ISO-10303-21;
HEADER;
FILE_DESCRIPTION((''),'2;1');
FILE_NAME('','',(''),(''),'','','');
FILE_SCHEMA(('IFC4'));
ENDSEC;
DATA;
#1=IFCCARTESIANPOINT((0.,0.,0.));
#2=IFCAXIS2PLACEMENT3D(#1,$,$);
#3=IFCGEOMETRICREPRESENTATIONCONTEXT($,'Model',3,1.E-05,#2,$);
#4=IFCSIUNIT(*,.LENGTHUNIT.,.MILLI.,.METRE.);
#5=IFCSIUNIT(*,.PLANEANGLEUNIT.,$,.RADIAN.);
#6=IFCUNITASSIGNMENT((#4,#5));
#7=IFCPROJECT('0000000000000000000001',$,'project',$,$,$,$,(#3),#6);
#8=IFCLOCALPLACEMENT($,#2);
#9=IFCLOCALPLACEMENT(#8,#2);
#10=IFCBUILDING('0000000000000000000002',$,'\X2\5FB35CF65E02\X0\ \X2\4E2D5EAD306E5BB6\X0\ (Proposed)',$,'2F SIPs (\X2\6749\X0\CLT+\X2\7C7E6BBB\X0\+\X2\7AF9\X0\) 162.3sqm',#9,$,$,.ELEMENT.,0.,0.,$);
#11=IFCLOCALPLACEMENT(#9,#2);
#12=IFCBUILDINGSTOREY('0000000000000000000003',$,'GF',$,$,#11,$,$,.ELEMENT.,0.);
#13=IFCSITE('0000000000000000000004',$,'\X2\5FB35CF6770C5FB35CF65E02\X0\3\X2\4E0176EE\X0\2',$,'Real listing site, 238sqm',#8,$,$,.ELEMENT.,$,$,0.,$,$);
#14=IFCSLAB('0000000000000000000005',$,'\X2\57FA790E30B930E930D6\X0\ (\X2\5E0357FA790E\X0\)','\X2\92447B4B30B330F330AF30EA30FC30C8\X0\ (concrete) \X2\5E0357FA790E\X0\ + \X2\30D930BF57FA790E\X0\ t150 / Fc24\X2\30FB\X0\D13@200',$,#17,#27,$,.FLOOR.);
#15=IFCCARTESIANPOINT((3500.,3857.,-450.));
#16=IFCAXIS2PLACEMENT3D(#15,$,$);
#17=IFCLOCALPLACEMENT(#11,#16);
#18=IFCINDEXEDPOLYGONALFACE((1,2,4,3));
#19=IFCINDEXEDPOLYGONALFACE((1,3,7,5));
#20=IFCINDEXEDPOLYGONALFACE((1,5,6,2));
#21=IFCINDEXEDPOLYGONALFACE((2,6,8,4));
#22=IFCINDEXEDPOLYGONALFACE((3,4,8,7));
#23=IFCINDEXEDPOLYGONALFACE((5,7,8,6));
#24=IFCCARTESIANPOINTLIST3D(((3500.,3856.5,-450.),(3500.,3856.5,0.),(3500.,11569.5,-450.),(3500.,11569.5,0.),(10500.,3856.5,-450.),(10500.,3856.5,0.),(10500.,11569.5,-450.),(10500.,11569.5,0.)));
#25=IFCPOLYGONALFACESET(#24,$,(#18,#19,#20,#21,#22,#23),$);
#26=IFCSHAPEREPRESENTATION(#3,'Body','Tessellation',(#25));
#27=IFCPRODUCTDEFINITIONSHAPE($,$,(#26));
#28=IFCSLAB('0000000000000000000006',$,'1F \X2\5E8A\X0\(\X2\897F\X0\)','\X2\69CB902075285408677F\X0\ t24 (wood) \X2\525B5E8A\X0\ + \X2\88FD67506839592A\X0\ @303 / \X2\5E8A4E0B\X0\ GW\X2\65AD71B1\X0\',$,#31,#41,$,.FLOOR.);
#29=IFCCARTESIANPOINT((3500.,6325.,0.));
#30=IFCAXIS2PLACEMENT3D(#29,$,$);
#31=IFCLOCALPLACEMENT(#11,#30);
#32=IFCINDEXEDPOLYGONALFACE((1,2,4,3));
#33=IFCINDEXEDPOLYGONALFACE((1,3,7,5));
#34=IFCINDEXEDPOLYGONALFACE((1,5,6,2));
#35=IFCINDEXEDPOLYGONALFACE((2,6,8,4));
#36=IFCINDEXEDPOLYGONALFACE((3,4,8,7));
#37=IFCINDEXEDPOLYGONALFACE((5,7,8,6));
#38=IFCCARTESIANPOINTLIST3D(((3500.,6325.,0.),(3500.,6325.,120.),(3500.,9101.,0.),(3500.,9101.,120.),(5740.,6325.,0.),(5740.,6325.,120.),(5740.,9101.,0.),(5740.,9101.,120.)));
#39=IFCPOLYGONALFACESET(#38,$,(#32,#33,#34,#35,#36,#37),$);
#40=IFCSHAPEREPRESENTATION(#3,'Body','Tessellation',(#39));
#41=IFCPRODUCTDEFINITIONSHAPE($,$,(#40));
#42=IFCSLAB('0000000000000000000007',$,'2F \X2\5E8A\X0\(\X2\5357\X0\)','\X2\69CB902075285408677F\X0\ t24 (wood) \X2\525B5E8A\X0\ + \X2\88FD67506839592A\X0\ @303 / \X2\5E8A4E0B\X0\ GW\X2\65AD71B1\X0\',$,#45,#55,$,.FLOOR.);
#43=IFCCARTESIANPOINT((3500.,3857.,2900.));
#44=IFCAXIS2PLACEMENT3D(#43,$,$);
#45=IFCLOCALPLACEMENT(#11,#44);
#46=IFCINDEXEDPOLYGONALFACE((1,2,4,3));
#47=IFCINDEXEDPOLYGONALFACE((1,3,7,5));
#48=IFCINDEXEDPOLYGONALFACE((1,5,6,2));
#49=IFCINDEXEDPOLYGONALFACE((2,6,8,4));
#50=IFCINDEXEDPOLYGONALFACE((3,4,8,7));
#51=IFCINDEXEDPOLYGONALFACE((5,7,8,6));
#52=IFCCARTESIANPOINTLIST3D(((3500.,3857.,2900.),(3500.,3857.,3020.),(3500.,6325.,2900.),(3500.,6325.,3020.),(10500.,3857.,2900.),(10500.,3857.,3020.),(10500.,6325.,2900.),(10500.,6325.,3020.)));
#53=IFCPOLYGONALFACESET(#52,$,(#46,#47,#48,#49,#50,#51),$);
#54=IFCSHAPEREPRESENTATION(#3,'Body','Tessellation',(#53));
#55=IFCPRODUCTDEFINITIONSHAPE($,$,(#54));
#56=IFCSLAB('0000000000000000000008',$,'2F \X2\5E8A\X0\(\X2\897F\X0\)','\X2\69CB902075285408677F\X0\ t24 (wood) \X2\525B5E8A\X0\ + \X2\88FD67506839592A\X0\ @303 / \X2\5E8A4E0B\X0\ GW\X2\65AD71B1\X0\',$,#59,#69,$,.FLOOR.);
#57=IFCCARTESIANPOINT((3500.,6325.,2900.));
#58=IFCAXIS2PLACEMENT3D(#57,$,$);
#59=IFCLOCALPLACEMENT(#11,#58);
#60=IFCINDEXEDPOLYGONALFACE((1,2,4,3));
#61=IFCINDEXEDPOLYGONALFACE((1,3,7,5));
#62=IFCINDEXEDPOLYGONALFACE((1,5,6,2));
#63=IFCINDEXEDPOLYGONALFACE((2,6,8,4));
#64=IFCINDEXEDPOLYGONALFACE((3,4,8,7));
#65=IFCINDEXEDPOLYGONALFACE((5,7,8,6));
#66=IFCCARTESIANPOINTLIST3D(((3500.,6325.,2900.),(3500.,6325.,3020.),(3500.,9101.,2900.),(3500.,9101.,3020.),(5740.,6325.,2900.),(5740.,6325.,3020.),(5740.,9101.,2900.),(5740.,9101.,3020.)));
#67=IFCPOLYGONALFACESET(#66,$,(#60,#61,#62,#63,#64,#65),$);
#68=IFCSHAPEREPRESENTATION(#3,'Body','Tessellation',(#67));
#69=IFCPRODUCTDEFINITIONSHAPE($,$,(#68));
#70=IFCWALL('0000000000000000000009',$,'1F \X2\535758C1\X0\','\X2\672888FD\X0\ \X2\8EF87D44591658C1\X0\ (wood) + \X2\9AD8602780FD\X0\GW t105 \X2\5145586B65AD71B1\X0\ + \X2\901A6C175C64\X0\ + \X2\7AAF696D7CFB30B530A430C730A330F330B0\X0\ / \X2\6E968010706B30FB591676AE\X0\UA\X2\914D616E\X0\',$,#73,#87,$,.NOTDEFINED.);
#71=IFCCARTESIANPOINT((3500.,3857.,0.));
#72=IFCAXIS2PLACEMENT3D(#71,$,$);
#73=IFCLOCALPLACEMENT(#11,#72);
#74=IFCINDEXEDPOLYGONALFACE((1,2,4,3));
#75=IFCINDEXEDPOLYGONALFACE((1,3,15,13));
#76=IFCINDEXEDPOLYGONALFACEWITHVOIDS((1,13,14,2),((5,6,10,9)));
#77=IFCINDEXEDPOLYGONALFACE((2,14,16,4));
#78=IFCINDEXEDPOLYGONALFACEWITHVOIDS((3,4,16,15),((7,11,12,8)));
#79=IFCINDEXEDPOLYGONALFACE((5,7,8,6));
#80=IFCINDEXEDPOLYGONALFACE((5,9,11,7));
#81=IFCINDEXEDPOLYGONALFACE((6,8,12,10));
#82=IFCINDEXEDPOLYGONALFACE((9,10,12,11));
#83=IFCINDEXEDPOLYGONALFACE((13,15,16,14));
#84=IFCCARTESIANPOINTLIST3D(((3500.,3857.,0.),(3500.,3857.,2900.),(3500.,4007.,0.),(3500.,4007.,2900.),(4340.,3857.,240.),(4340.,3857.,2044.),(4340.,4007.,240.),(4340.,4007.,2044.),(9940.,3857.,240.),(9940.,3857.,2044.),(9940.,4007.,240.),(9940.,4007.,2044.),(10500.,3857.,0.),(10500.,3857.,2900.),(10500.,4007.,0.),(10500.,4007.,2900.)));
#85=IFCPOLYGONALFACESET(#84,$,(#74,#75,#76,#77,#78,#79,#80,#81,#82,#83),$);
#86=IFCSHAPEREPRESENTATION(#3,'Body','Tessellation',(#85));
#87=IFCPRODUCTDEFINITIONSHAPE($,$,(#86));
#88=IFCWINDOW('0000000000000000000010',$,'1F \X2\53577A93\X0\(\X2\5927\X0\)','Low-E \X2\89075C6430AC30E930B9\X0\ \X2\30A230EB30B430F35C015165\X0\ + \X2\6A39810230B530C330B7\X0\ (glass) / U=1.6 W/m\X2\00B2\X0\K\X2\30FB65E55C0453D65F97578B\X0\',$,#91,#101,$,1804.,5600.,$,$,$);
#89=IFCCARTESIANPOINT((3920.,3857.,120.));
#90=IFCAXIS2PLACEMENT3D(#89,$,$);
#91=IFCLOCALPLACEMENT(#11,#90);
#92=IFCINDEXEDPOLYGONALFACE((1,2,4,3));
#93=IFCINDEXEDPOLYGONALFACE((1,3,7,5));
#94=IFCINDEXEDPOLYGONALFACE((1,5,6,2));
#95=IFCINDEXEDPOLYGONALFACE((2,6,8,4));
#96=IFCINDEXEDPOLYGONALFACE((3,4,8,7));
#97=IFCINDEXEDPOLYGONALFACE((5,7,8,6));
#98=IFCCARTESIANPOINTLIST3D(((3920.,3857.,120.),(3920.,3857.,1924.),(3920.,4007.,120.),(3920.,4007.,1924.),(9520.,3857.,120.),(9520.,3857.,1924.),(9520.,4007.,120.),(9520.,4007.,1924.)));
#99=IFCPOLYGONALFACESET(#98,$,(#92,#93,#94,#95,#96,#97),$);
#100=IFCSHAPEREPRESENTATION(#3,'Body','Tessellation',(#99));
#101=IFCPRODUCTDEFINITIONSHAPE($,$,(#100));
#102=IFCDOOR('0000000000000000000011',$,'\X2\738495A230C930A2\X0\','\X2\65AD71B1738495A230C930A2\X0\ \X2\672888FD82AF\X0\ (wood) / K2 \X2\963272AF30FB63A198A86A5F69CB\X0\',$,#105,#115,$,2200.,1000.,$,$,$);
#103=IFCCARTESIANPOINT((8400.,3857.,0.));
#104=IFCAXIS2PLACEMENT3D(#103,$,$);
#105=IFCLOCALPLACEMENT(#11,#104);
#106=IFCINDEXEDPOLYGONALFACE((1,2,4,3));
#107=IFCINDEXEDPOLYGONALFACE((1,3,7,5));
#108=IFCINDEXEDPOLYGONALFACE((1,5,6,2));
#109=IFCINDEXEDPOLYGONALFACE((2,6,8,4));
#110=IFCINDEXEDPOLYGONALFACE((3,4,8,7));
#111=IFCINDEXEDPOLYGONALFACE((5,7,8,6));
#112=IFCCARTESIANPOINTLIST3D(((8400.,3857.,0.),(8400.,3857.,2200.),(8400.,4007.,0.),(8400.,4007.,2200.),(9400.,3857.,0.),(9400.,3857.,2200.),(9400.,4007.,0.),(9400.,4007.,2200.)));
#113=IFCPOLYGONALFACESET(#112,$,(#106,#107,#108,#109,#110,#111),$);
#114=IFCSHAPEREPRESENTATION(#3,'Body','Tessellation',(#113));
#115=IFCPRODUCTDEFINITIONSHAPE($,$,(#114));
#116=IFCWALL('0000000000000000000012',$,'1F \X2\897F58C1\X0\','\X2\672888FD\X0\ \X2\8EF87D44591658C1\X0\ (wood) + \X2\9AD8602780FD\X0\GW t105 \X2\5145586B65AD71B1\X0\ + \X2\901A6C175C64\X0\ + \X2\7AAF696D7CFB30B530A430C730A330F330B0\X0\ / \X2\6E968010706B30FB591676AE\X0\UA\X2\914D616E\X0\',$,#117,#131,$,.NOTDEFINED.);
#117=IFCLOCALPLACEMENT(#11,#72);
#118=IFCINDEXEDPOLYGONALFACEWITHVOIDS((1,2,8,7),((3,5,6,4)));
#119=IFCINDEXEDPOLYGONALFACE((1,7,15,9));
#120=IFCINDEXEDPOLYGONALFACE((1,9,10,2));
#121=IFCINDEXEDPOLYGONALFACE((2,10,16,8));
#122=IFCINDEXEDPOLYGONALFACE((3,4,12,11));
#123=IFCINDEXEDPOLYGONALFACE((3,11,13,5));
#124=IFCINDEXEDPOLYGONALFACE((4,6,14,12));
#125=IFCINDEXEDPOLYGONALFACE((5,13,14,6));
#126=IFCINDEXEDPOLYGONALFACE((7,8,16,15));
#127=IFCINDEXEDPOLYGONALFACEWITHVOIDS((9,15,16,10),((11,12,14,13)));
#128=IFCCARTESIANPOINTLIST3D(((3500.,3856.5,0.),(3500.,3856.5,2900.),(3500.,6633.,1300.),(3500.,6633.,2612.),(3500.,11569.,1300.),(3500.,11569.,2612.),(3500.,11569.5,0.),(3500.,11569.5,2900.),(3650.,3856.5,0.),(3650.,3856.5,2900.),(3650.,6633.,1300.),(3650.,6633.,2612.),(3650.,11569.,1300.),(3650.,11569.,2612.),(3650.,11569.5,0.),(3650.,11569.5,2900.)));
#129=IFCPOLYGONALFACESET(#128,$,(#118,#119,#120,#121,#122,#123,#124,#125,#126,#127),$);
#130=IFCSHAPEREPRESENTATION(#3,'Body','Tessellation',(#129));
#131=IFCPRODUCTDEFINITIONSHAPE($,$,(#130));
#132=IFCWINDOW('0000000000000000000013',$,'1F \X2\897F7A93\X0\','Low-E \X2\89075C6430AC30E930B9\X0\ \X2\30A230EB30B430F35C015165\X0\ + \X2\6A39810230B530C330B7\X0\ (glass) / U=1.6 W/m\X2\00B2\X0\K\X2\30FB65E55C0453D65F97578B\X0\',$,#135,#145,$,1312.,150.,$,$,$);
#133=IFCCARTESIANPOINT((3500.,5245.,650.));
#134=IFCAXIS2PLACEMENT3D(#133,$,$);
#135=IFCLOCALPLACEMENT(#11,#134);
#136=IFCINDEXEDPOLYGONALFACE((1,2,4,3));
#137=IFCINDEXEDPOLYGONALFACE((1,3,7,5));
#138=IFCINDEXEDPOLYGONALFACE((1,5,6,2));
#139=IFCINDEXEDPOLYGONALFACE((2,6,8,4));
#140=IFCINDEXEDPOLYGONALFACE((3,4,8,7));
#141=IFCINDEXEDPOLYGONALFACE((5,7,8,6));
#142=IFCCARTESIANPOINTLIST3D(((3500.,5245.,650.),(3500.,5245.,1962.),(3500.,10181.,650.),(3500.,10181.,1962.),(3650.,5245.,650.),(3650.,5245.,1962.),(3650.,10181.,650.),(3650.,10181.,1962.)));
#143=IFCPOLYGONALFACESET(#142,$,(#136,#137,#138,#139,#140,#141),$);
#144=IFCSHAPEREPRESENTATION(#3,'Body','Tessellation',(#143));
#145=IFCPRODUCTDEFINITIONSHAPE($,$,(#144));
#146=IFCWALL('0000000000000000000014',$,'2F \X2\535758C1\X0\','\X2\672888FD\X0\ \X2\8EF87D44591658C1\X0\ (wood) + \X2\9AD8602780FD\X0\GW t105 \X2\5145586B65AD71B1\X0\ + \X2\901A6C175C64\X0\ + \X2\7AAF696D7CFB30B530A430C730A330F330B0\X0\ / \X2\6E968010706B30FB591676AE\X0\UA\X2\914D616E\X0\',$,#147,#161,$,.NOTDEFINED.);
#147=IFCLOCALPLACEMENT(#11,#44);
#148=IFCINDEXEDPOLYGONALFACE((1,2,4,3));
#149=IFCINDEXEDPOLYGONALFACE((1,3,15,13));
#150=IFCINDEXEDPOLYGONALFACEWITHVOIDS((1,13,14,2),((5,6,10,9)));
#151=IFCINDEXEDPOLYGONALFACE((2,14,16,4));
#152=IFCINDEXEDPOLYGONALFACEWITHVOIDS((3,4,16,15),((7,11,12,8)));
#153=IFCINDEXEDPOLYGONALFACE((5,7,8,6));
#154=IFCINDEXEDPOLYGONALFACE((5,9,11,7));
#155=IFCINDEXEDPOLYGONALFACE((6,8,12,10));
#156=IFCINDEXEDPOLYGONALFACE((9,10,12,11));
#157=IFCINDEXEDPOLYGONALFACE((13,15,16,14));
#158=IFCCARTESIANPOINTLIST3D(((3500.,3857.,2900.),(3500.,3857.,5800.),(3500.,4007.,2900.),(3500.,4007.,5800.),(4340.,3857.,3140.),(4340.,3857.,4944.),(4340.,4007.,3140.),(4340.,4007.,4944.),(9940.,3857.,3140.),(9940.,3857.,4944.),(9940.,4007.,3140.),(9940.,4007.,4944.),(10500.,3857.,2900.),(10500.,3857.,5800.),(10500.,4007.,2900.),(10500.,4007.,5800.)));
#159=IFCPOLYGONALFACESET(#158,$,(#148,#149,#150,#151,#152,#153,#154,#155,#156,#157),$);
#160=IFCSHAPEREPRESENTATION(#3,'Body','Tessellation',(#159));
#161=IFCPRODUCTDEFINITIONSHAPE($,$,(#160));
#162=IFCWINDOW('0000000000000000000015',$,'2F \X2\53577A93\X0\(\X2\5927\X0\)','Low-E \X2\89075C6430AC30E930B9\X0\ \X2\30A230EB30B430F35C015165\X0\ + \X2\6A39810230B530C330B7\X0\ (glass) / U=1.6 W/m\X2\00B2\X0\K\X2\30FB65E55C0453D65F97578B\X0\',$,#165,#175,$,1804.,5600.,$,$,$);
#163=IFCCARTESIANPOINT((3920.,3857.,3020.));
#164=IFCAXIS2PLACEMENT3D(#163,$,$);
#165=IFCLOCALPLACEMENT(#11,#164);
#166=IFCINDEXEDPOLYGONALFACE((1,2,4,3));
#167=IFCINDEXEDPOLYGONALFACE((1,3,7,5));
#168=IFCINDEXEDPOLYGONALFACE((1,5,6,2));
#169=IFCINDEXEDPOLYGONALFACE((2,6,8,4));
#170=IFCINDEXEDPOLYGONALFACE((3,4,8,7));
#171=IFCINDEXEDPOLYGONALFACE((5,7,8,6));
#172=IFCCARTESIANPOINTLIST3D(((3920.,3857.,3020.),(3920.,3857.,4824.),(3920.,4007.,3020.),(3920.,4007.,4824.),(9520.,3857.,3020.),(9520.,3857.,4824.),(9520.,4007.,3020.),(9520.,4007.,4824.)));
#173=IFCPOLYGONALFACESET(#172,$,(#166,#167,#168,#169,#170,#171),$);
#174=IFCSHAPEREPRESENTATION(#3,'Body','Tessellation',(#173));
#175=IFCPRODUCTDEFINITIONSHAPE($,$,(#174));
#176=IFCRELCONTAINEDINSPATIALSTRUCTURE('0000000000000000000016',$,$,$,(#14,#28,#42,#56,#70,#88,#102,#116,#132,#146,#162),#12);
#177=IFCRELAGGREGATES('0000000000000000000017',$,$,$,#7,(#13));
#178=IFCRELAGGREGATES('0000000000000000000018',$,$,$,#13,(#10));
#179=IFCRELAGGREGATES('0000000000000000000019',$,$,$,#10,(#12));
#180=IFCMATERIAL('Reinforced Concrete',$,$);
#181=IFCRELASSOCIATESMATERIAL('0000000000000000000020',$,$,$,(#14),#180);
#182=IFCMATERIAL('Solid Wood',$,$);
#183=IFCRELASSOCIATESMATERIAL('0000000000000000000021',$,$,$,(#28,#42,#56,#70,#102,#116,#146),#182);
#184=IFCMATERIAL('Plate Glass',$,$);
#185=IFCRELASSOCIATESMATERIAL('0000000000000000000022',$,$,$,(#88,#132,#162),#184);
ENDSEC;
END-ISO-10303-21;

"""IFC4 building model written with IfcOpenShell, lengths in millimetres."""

from ifc_helpers import new_model, si_unit, frame, frame_2d, origin, place, context, project, spatial, rectangle, extrude, material, element, fill, save


model = new_model("IFC4")

# Units and contexts
model_context = context("Model", 3, precision=1e-05, world=origin())
ifc_project = project(units=[si_unit("LENGTHUNIT", "METRE", prefix="MILLI"), si_unit("PLANEANGLEUNIT", "RADIAN")], contexts=[model_context])

# Site, building, storey
site_placement = place(None, origin())
site = spatial("IfcSite", under=ifc_project, at=site_placement, Name="徳島県徳島市3丁目2", ObjectType="Real listing site, 238sqm", CompositionType="ELEMENT", RefElevation=0.0)
building_placement = place(site_placement, origin())
building = spatial("IfcBuilding", under=site, at=building_placement, Name="徳島市 中庭の家 (Proposed)", ObjectType="2F SIPs (杉CLT+籾殻+竹) 162.3sqm", CompositionType="ELEMENT", ElevationOfRefHeight=0.0, ElevationOfTerrain=0.0)
storey_placement = place(building_placement, origin())
storey = spatial("IfcBuildingStorey", under=building, at=storey_placement, Name="GF", CompositionType="ELEMENT", Elevation=0.0)

# Slabs
ifc_material_1 = material(Name="Reinforced Concrete")
slab_1_placement = place(storey_placement, frame((3500.0, 3857.0, -450.0)))
element("IfcSlab", 1, at=slab_1_placement, inside=storey, material=ifc_material_1, Name="基礎スラブ (布基礎)", Description="鉄筋コンクリート (concrete) 布基礎 + ベタ基礎 t150 / Fc24・D13@200", PredefinedType="FLOOR", context=model_context, shape_type="SweptSolid", body=[
    extrude(rectangle(XDim=7000.0, YDim=7713.0, at=frame_2d((3500.0, 3856.0))), frame((3500.0, 3857.0, -450.0)), (0.0, 0.0, 1.0), 450.0),
])
ifc_material_2 = material(Name="Solid Wood")
slab_2_placement = place(storey_placement, frame((3500.0, 6325.0, 0.0)))
element("IfcSlab", 2, at=slab_2_placement, inside=storey, material=ifc_material_2, Name="1F 床(西)", Description="構造用合板 t24 (wood) 剛床 + 製材根太 @303 / 床下 GW断熱", PredefinedType="FLOOR", context=model_context, shape_type="SweptSolid", body=[
    extrude(rectangle(XDim=2240.0, YDim=2776.0, at=frame_2d((1120.0, 1388.0))), frame((3500.0, 6325.0, 0.0)), (0.0, 0.0, 1.0), 120.0),
])
slab_3_placement = place(storey_placement, frame((3500.0, 3857.0, 2900.0)))
element("IfcSlab", 3, at=slab_3_placement, inside=storey, material=ifc_material_2, Name="2F 床(南)", Description="構造用合板 t24 (wood) 剛床 + 製材根太 @303 / 床下 GW断熱", PredefinedType="FLOOR", context=model_context, shape_type="SweptSolid", body=[
    extrude(rectangle(XDim=7000.0, YDim=2468.0, at=frame_2d((3500.0, 1234.0))), frame((3500.0, 3857.0, 2900.0)), (0.0, 0.0, 1.0), 120.0),
])
slab_4_placement = place(storey_placement, frame((3500.0, 6325.0, 2900.0)))
element("IfcSlab", 4, at=slab_4_placement, inside=storey, material=ifc_material_2, Name="2F 床(西)", Description="構造用合板 t24 (wood) 剛床 + 製材根太 @303 / 床下 GW断熱", PredefinedType="FLOOR", context=model_context, shape_type="SweptSolid", body=[
    extrude(rectangle(XDim=2240.0, YDim=2776.0, at=frame_2d((1120.0, 1388.0))), frame((3500.0, 6325.0, 2900.0)), (0.0, 0.0, 1.0), 120.0),
])

# Wall, openings, window, door
wall_1_placement = place(storey_placement, frame((3500.0, 3857.0, 0.0)))
wall_1 = element("IfcWall", 5, at=wall_1_placement, inside=storey, material=ifc_material_2, Name="1F 南壁", Description="木製 軸組外壁 (wood) + 高性能GW t105 充填断熱 + 通気層 + 窯業系サイディング / 準耐火・外皮UA配慮", PredefinedType="NOTDEFINED", context=model_context, shape_type="SweptSolid", body=[
    extrude(rectangle(XDim=7000.0, YDim=150.0, at=frame_2d((3500.0, 75.0))), frame((3500.0, 3857.0, 0.0)), (0.0, 0.0, 1.0), 2900.0),
])
opening_1_placement = place(storey_placement, frame((3920.0, 3857.0, 120.0)))
opening_1 = element("IfcOpeningElement", 6, at=opening_1_placement, cuts=wall_1, PredefinedType="NOTDEFINED", context=model_context, shape_type="SweptSolid", body=[
    extrude(rectangle(XDim=5600.0, YDim=150.0, at=frame_2d((2800.0, 75.0))), frame((3920.0, 3857.0, 120.0)), (0.0, 0.0, 1.0), 1804.0),
])
opening_2_placement = place(storey_placement, frame((8400.0, 3857.0, 0.0)))
opening_2 = element("IfcOpeningElement", 7, at=opening_2_placement, cuts=wall_1, PredefinedType="NOTDEFINED", context=model_context, shape_type="SweptSolid", body=[
    extrude(rectangle(XDim=1000.0, YDim=150.0, at=frame_2d((500.0, 75.0))), frame((8400.0, 3857.0, 0.0)), (0.0, 0.0, 1.0), 2200.0),
])
ifc_material_3 = material(Name="Plate Glass")
window_1_placement = place(storey_placement, frame((3920.0, 3857.0, 120.0)))
window_1 = element("IfcWindow", 8, at=window_1_placement, inside=storey, material=ifc_material_3, Name="1F 南窓(大)", Description="Low-E 複層ガラス アルゴン封入 + 樹脂サッシ (glass) / U=1.6 W/m²K・日射取得型", OverallHeight=1804.0, OverallWidth=5600.0, context=model_context, shape_type="SweptSolid", body=[
    extrude(rectangle(XDim=5600.0, YDim=150.0, at=frame_2d((2800.0, 75.0))), frame((3920.0, 3857.0, 120.0)), (0.0, 0.0, 1.0), 1804.0),
])
fill(opening_1, window_1)
door_placement = place(storey_placement, frame((8400.0, 3857.0, 0.0)))
door = element("IfcDoor", 9, at=door_placement, inside=storey, material=ifc_material_2, Name="玄関ドア", Description="断熱玄関ドア 木製芯 (wood) / K2 防犯・採風機構", OverallHeight=2200.0, OverallWidth=1000.0, context=model_context, shape_type="SweptSolid", body=[
    extrude(rectangle(XDim=1000.0, YDim=150.0, at=frame_2d((500.0, 75.0))), frame((8400.0, 3857.0, 0.0)), (0.0, 0.0, 1.0), 2200.0),
])
fill(opening_2, door)

# Walls, openings, windows
wall_2_placement = place(storey_placement, frame((3500.0, 3857.0, 0.0)))
wall_2 = element("IfcWall", 10, at=wall_2_placement, inside=storey, material=ifc_material_2, Name="1F 西壁", Description="木製 軸組外壁 (wood) + 高性能GW t105 充填断熱 + 通気層 + 窯業系サイディング / 準耐火・外皮UA配慮", PredefinedType="NOTDEFINED", context=model_context, shape_type="SweptSolid", body=[
    extrude(rectangle(XDim=150.0, YDim=7713.0, at=frame_2d((75.0, 3856.0))), frame((3500.0, 3857.0, 0.0)), (0.0, 0.0, 1.0), 2900.0),
])
opening_3_placement = place(storey_placement, frame((3500.0, 5245.0, 650.0)))
opening_3 = element("IfcOpeningElement", 11, at=opening_3_placement, cuts=wall_2, PredefinedType="NOTDEFINED", context=model_context, shape_type="SweptSolid", body=[
    extrude(rectangle(XDim=150.0, YDim=4936.0, at=frame_2d((75.0, 2468.0))), frame((3500.0, 5245.0, 650.0)), (0.0, 0.0, 1.0), 1312.0),
])
window_2_placement = place(storey_placement, frame((3500.0, 5245.0, 650.0)))
window_2 = element("IfcWindow", 12, at=window_2_placement, inside=storey, material=ifc_material_3, Name="1F 西窓", Description="Low-E 複層ガラス アルゴン封入 + 樹脂サッシ (glass) / U=1.6 W/m²K・日射取得型", OverallHeight=1312.0, OverallWidth=150.0, context=model_context, shape_type="SweptSolid", body=[
    extrude(rectangle(XDim=150.0, YDim=4936.0, at=frame_2d((75.0, 2468.0))), frame((3500.0, 5245.0, 650.0)), (0.0, 0.0, 1.0), 1312.0),
])
fill(opening_3, window_2)
wall_3_placement = place(storey_placement, frame((3500.0, 3857.0, 2900.0)))
wall_3 = element("IfcWall", 13, at=wall_3_placement, inside=storey, material=ifc_material_2, Name="2F 南壁", Description="木製 軸組外壁 (wood) + 高性能GW t105 充填断熱 + 通気層 + 窯業系サイディング / 準耐火・外皮UA配慮", PredefinedType="NOTDEFINED", context=model_context, shape_type="SweptSolid", body=[
    extrude(rectangle(XDim=7000.0, YDim=150.0, at=frame_2d((3500.0, 75.0))), frame((3500.0, 3857.0, 2900.0)), (0.0, 0.0, 1.0), 2900.0),
])
opening_4_placement = place(storey_placement, frame((3920.0, 3857.0, 3020.0)))
opening_4 = element("IfcOpeningElement", 14, at=opening_4_placement, cuts=wall_3, PredefinedType="NOTDEFINED", context=model_context, shape_type="SweptSolid", body=[
    extrude(rectangle(XDim=5600.0, YDim=150.0, at=frame_2d((2800.0, 75.0))), frame((3920.0, 3857.0, 3020.0)), (0.0, 0.0, 1.0), 1804.0),
])
window_3_placement = place(storey_placement, frame((3920.0, 3857.0, 3020.0)))
window_3 = element("IfcWindow", 15, at=window_3_placement, inside=storey, material=ifc_material_3, Name="2F 南窓(大)", Description="Low-E 複層ガラス アルゴン封入 + 樹脂サッシ (glass) / U=1.6 W/m²K・日射取得型", OverallHeight=1804.0, OverallWidth=5600.0, context=model_context, shape_type="SweptSolid", body=[
    extrude(rectangle(XDim=5600.0, YDim=150.0, at=frame_2d((2800.0, 75.0))), frame((3920.0, 3857.0, 3020.0)), (0.0, 0.0, 1.0), 1804.0),
])
fill(opening_4, window_3)

save(model, "model.ifc")
